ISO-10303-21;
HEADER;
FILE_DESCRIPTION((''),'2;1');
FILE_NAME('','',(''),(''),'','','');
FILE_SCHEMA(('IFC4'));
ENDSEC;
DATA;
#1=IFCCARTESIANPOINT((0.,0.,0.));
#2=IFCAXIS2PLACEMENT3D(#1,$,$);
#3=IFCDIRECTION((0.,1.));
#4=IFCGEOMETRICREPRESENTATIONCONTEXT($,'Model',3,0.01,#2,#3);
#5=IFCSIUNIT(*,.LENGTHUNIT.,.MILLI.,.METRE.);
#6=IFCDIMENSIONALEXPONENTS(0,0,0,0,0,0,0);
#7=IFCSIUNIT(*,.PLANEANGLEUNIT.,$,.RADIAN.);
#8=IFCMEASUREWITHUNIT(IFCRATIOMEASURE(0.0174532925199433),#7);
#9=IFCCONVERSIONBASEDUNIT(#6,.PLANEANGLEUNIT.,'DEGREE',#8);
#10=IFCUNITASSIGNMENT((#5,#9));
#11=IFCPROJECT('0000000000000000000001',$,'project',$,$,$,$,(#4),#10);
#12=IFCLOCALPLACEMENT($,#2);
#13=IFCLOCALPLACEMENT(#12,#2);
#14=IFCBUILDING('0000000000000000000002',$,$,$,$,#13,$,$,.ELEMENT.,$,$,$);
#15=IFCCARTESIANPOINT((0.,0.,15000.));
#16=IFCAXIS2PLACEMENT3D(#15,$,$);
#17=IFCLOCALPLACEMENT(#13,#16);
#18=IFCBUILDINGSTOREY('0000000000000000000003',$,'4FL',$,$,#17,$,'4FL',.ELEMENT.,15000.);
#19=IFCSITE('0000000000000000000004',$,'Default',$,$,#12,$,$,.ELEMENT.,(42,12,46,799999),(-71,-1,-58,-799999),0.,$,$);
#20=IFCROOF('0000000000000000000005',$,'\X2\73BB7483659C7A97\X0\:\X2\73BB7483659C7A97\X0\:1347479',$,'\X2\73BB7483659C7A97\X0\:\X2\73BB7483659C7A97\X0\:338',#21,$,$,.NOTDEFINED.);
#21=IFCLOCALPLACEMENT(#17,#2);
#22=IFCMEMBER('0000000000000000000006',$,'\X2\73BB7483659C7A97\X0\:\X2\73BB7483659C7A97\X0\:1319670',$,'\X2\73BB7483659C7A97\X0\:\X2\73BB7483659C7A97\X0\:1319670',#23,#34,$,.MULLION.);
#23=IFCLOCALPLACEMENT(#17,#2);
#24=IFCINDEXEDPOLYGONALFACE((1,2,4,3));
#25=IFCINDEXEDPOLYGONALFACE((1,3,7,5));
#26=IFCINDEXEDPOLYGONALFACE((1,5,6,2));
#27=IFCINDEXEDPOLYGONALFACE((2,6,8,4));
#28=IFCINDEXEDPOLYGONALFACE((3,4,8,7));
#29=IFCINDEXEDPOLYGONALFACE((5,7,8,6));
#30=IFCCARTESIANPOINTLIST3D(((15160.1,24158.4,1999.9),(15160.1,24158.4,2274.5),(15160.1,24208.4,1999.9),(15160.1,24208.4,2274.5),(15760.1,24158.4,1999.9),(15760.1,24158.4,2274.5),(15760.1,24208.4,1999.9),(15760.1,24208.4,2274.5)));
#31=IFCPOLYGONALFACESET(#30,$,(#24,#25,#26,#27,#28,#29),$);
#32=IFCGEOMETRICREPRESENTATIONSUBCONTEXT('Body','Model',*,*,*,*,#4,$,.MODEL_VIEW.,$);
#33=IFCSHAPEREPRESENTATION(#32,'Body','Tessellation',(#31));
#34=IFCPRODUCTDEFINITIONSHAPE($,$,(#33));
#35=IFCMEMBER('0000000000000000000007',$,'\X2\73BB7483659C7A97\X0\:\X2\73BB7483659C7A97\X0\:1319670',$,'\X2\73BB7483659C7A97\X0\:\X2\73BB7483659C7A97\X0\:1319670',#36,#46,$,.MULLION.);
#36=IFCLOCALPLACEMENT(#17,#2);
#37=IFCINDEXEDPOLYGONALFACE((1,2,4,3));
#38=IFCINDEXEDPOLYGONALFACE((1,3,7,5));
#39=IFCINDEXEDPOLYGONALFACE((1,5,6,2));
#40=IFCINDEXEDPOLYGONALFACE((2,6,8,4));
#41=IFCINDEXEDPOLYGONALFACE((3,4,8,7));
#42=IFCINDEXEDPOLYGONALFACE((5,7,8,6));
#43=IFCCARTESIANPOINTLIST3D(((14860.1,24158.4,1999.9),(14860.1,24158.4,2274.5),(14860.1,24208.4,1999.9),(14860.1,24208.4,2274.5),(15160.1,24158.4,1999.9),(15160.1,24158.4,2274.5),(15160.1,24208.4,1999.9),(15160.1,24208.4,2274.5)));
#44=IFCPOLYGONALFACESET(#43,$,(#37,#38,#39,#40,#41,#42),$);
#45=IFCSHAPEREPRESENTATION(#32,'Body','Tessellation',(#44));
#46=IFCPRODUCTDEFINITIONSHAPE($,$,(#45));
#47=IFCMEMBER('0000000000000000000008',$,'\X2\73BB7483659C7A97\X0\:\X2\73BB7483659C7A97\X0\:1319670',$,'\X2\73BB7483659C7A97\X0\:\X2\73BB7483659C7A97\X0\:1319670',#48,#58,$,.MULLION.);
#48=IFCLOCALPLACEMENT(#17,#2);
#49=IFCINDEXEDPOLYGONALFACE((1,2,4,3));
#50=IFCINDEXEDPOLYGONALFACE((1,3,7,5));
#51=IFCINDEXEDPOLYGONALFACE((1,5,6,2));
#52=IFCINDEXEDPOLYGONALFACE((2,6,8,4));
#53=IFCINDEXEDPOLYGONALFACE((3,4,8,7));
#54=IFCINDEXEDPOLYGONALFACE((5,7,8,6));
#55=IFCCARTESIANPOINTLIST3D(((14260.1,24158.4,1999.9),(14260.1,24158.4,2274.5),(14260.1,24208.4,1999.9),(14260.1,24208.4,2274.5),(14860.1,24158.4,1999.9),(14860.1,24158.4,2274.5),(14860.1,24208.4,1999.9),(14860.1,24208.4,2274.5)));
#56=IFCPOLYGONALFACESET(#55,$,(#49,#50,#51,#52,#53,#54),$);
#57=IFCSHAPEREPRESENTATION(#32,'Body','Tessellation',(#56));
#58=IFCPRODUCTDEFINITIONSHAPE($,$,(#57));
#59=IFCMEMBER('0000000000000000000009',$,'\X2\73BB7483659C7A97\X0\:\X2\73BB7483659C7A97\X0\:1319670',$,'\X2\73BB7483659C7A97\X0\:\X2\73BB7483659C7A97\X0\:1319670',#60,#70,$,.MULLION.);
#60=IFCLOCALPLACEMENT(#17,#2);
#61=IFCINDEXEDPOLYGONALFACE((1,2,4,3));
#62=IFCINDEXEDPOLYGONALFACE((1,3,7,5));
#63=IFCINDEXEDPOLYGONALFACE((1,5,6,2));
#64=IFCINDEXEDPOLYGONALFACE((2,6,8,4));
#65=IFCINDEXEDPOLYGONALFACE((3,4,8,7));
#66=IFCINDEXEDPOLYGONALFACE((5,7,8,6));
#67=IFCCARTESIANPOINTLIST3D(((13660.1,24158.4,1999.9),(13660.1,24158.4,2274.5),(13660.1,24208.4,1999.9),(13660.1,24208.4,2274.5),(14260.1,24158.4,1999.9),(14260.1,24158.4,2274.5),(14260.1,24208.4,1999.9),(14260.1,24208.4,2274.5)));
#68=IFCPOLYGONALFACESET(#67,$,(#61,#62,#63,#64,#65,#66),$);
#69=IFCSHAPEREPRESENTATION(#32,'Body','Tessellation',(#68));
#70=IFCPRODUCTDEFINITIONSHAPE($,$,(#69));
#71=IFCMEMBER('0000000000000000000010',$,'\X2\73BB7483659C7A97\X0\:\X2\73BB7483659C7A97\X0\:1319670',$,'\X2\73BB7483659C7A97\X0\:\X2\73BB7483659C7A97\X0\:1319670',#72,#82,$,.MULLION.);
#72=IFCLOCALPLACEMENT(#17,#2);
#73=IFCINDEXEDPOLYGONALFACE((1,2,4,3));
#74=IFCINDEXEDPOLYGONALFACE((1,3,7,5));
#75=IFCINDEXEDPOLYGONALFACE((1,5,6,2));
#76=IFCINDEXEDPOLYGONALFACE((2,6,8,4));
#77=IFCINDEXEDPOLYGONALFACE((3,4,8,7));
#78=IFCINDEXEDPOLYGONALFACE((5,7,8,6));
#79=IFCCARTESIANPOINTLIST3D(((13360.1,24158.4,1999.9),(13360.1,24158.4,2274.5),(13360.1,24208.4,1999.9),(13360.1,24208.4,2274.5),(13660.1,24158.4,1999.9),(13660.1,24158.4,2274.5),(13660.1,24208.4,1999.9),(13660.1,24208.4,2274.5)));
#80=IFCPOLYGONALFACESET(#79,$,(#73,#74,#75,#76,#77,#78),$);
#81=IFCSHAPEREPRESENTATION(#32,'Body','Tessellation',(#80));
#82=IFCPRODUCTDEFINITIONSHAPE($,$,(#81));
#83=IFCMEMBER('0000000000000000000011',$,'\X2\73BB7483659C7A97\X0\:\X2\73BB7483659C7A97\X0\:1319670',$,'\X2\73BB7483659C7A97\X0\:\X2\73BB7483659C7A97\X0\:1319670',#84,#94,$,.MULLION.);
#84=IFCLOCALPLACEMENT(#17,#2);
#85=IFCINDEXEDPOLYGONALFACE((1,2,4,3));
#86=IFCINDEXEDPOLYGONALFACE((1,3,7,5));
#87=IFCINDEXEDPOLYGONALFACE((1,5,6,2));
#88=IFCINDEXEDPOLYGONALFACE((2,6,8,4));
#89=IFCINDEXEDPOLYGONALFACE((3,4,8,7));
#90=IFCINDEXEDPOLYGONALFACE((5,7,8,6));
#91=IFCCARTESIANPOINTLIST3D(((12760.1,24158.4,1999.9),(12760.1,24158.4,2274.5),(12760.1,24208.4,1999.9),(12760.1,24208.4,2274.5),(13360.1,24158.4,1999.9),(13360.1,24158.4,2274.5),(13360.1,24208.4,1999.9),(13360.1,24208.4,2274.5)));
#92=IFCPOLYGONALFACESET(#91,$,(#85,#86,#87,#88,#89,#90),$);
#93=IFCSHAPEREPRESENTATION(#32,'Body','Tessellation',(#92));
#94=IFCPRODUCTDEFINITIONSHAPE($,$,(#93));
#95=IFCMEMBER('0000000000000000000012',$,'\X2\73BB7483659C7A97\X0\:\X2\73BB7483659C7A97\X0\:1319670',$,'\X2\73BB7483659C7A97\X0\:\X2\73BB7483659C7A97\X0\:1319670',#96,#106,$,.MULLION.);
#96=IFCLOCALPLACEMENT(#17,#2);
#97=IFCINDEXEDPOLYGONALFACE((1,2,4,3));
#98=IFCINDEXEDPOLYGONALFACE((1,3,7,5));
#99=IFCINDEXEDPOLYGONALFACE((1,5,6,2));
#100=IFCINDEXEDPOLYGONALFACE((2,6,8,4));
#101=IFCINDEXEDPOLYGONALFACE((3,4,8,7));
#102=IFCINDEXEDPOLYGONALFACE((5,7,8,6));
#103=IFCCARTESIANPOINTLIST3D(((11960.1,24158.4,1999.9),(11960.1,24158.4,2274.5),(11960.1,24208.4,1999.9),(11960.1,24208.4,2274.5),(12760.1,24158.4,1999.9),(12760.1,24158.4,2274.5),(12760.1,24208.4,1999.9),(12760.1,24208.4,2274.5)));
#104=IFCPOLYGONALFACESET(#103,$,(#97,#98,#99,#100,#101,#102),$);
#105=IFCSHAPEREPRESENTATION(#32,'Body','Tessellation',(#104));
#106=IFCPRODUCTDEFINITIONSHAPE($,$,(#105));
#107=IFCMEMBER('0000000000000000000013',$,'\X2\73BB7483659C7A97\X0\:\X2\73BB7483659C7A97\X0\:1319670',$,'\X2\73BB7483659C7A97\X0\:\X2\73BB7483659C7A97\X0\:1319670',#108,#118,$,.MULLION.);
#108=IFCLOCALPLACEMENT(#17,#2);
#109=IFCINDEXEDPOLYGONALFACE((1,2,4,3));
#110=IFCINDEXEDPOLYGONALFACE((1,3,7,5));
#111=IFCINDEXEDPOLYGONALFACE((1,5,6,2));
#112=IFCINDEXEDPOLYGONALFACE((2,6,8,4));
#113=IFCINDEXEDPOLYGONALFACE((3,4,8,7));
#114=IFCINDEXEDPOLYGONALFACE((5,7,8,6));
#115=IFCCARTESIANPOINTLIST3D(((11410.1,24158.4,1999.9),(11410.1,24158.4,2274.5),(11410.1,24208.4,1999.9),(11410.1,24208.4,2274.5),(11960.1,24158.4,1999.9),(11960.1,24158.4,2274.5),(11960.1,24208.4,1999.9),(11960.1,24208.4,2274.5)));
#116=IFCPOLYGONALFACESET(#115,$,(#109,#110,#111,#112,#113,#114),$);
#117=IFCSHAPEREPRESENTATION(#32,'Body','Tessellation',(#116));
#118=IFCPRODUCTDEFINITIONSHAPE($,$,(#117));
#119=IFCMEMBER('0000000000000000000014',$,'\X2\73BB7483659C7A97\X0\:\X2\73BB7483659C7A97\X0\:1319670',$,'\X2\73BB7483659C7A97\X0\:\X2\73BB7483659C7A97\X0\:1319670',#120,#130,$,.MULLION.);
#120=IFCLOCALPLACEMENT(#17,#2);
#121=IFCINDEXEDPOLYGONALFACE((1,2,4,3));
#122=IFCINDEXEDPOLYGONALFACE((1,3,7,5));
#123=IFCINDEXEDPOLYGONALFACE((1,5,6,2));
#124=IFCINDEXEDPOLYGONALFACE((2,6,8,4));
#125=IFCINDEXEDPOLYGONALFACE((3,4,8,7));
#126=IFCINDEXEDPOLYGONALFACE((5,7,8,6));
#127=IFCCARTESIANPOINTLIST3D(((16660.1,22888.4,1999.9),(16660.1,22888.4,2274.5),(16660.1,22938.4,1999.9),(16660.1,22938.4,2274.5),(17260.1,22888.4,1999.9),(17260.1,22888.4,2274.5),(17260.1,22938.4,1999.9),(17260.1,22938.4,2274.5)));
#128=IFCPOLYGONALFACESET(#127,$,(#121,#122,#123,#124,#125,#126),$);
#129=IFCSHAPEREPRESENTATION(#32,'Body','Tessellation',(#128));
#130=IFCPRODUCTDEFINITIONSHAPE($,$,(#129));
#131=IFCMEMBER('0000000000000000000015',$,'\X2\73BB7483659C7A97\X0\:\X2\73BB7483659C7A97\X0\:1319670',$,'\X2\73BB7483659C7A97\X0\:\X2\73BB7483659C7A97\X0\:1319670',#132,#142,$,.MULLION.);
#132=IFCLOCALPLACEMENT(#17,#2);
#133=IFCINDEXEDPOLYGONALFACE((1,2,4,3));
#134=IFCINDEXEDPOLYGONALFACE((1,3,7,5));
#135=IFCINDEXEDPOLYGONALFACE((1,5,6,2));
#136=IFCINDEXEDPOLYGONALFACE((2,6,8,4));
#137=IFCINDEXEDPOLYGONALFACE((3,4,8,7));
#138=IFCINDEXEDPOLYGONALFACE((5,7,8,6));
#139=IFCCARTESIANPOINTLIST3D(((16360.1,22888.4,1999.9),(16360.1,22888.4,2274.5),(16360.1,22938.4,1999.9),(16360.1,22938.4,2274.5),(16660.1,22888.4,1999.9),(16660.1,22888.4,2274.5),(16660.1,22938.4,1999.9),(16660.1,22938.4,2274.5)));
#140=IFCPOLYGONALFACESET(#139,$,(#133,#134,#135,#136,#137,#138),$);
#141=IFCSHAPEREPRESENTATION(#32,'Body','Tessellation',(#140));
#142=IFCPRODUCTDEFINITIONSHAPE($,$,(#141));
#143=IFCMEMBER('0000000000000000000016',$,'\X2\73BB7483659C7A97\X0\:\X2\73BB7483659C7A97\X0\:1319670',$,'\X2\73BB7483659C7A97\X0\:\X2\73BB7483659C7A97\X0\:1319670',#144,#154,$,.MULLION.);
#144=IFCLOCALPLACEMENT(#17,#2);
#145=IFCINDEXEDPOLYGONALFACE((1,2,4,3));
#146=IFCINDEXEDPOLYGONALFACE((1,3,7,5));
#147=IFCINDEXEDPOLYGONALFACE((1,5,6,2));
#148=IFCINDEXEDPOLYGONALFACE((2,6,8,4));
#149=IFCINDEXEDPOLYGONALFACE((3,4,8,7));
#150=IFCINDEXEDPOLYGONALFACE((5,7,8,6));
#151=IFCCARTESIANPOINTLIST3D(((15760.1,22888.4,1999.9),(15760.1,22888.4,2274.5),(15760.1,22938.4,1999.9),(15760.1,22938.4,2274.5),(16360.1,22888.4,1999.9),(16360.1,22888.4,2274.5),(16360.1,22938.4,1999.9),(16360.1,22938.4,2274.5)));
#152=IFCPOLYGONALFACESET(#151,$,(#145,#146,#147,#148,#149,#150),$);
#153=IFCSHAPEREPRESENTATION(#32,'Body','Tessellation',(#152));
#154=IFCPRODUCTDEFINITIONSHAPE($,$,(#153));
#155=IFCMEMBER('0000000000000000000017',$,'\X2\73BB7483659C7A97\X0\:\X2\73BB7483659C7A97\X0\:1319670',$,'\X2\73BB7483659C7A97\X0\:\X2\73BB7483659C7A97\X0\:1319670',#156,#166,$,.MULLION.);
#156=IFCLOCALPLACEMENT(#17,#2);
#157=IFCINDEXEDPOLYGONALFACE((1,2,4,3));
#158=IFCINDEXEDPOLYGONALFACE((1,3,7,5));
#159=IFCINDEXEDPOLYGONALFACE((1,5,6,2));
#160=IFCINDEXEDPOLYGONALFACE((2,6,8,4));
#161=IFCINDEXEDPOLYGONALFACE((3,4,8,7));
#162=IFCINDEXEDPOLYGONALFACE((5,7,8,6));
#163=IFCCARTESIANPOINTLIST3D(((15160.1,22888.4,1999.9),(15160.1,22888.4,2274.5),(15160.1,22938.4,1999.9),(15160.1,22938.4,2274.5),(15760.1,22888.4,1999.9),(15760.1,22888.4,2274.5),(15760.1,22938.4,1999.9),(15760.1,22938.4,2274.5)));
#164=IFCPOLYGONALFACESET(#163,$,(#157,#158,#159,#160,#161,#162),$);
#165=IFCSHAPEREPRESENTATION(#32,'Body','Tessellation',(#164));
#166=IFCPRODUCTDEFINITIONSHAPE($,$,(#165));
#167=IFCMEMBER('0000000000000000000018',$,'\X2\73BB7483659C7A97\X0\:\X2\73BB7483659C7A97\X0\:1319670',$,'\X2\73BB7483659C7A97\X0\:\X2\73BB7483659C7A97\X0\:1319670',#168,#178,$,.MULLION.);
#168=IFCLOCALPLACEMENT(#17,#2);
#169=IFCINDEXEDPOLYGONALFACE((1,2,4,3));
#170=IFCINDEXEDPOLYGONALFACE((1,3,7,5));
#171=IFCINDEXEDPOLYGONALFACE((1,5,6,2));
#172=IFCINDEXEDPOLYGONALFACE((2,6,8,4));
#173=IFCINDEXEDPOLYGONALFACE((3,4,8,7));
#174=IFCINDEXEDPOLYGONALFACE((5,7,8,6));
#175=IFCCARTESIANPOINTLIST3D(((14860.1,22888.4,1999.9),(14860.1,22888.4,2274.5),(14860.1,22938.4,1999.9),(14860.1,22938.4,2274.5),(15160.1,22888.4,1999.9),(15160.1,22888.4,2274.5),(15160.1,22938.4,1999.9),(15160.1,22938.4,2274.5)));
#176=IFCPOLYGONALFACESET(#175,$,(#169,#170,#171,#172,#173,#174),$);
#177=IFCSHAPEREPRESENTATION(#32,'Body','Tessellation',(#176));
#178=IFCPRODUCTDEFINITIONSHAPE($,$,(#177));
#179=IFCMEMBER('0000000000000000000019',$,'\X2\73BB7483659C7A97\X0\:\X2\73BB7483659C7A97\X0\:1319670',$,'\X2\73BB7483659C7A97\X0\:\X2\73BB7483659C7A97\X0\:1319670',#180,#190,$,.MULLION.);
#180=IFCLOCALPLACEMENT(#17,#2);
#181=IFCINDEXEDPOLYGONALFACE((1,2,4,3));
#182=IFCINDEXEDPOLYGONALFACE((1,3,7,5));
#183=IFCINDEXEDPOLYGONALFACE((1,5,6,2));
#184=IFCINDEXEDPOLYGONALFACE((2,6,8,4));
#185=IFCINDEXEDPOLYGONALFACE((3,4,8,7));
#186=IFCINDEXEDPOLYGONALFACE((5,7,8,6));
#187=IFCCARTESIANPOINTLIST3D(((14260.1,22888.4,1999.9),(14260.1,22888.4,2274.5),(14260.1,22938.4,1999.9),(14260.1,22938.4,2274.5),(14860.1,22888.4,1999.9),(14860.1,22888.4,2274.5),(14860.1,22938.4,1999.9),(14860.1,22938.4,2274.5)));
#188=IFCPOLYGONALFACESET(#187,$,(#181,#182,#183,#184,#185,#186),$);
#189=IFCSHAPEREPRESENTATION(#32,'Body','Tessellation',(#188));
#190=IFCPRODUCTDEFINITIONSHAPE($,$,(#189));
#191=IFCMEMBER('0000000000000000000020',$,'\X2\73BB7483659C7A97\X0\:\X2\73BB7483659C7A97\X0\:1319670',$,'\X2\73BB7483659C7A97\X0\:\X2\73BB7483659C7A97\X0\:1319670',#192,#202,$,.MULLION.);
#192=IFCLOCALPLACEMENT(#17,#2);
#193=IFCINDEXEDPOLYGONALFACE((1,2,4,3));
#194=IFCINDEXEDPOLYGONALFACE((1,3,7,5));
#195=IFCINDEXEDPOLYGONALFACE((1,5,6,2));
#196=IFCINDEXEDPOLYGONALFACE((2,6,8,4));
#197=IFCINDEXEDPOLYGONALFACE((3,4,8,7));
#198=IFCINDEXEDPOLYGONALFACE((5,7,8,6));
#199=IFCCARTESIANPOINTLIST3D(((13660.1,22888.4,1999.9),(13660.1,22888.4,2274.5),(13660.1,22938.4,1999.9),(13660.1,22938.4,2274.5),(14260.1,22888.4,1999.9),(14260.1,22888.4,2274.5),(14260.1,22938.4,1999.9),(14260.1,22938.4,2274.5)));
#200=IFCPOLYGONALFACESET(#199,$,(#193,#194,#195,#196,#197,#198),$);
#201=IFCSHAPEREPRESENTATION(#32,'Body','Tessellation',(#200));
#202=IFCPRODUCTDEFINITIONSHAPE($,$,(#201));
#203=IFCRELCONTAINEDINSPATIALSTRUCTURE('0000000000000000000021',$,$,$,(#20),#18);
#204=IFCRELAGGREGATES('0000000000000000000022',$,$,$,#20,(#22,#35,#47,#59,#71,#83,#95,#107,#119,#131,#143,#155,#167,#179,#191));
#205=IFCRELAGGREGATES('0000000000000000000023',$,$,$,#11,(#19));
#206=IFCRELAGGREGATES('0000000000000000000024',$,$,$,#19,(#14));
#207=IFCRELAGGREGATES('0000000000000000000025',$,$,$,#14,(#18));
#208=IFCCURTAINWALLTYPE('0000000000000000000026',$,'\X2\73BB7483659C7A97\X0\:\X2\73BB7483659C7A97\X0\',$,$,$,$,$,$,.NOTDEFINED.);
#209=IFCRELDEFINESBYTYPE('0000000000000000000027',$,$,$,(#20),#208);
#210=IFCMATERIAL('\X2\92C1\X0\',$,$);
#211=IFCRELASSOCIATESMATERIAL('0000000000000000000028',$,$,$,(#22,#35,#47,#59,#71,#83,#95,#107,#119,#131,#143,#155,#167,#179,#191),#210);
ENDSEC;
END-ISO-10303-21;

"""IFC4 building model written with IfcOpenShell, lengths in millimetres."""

from ifc_helpers import new_model, entity, si_unit, converted_unit, direction, frame, frame_2d, origin, place, context, subcontext, project, spatial, rectangle, extrude, material, type_object, element, aggregate, save


model = new_model("IFC4")

# Units and contexts
model_context = context("Model", 3, precision=0.01, world=origin(), true_north=direction((0.0, 1.0)))
body_context = subcontext(model_context, "Body", "Model", "MODEL_VIEW")
ifc_project = project(units=[si_unit("LENGTHUNIT", "METRE", prefix="MILLI"), converted_unit("PLANEANGLEUNIT", "DEGREE", entity("IfcRatioMeasure", 0.0174532925199433), si_unit("PLANEANGLEUNIT", "RADIAN"), dimensions=[0, 0, 0, 0, 0, 0, 0])], contexts=[model_context])

# Site, building, storey
site_placement = place(None, origin())
site = spatial("IfcSite", under=ifc_project, at=site_placement, Name="Default", CompositionType="ELEMENT", RefLatitude=(42, 12, 46, 799999), RefLongitude=(-71, -1, -58, -799999), RefElevation=0.0)
building_placement = place(site_placement, origin())
building = spatial("IfcBuilding", under=site, at=building_placement, CompositionType="ELEMENT")
storey_placement = place(building_placement, frame((0.0, 0.0, 15000.0)))
storey = spatial("IfcBuildingStorey", under=building, at=storey_placement, Name="4FL", LongName="4FL", CompositionType="ELEMENT", Elevation=15000.0)

# Roof, members
curtain_wall_type = type_object("IfcCurtainWallType", Name="玻璃斜窗:玻璃斜窗", PredefinedType="NOTDEFINED")
roof_1_placement = place(storey_placement, frame((0.0, 0.0, -15000.0)))
roof_1 = element("IfcRoof", 1, at=roof_1_placement, inside=storey, type_object=curtain_wall_type, Name="玻璃斜窗:玻璃斜窗:1347479", ObjectType="玻璃斜窗:玻璃斜窗:338", PredefinedType="NOTDEFINED")
ifc_material = material(Name="鋁")
member_1_placement = place(roof_1_placement, frame((0.0, 0.0, 15000.0)))
member_1 = element("IfcMember", 2, at=member_1_placement, material=ifc_material, Name="玻璃斜窗:玻璃斜窗:1319670", ObjectType="玻璃斜窗:玻璃斜窗:1319670", PredefinedType="MULLION", context=body_context, shape_type="SweptSolid", body=[
    extrude(rectangle(XDim=274.5, YDim=50.0, at=frame_2d((0.0, 0.0), x_axis=(1.0, 0.0))), frame((15160.1, 24183.4, 2137.2), z_axis=(1.0, 0.0, 0.0), x_axis=(0.0, 0.0, -1.0)), (0.0, 0.0, 1.0), 600.0),
])
member_2_placement = place(roof_1_placement, frame((0.0, 0.0, 15000.0)))
member_2 = element("IfcMember", 3, at=member_2_placement, material=ifc_material, Name="玻璃斜窗:玻璃斜窗:1319670", ObjectType="玻璃斜窗:玻璃斜窗:1319670", PredefinedType="MULLION", context=body_context, shape_type="SweptSolid", body=[
    extrude(rectangle(XDim=274.5, YDim=50.0, at=frame_2d((0.0, 0.0), x_axis=(1.0, 0.0))), frame((14860.1, 24183.4, 2137.2), z_axis=(1.0, 0.0, 0.0), x_axis=(0.0, 0.0, -1.0)), (0.0, 0.0, 1.0), 300.0),
])
member_3_placement = place(roof_1_placement, frame((0.0, 0.0, 15000.0)))
member_3 = element("IfcMember", 4, at=member_3_placement, material=ifc_material, Name="玻璃斜窗:玻璃斜窗:1319670", ObjectType="玻璃斜窗:玻璃斜窗:1319670", PredefinedType="MULLION", context=body_context, shape_type="SweptSolid", body=[
    extrude(rectangle(XDim=274.5, YDim=50.0, at=frame_2d((0.0, 0.0), x_axis=(1.0, 0.0))), frame((14260.1, 24183.4, 2137.2), z_axis=(1.0, 0.0, 0.0), x_axis=(0.0, 0.0, -1.0)), (0.0, 0.0, 1.0), 600.0),
])
member_4_placement = place(roof_1_placement, frame((0.0, 0.0, 15000.0)))
member_4 = element("IfcMember", 5, at=member_4_placement, material=ifc_material, Name="玻璃斜窗:玻璃斜窗:1319670", ObjectType="玻璃斜窗:玻璃斜窗:1319670", PredefinedType="MULLION", context=body_context, shape_type="SweptSolid", body=[
    extrude(rectangle(XDim=274.5, YDim=50.0, at=frame_2d((0.0, 0.0), x_axis=(1.0, 0.0))), frame((13660.1, 24183.4, 2137.2), z_axis=(1.0, 0.0, 0.0), x_axis=(0.0, 0.0, -1.0)), (0.0, 0.0, 1.0), 600.0),
])
member_5_placement = place(roof_1_placement, frame((0.0, 0.0, 15000.0)))
member_5 = element("IfcMember", 6, at=member_5_placement, material=ifc_material, Name="玻璃斜窗:玻璃斜窗:1319670", ObjectType="玻璃斜窗:玻璃斜窗:1319670", PredefinedType="MULLION", context=body_context, shape_type="SweptSolid", body=[
    extrude(rectangle(XDim=274.5, YDim=50.0, at=frame_2d((0.0, 0.0), x_axis=(1.0, 0.0))), frame((13360.1, 24183.4, 2137.2), z_axis=(1.0, 0.0, 0.0), x_axis=(0.0, 0.0, -1.0)), (0.0, 0.0, 1.0), 300.0),
])
member_6_placement = place(roof_1_placement, frame((0.0, 0.0, 15000.0)))
member_6 = element("IfcMember", 7, at=member_6_placement, material=ifc_material, Name="玻璃斜窗:玻璃斜窗:1319670", ObjectType="玻璃斜窗:玻璃斜窗:1319670", PredefinedType="MULLION", context=body_context, shape_type="SweptSolid", body=[
    extrude(rectangle(XDim=274.5, YDim=50.0, at=frame_2d((0.0, 0.0), x_axis=(1.0, 0.0))), frame((12760.1, 24183.4, 2137.2), z_axis=(1.0, 0.0, 0.0), x_axis=(0.0, 0.0, -1.0)), (0.0, 0.0, 1.0), 600.0),
])
member_7_placement = place(roof_1_placement, frame((0.0, 0.0, 15000.0)))
member_7 = element("IfcMember", 8, at=member_7_placement, material=ifc_material, Name="玻璃斜窗:玻璃斜窗:1319670", ObjectType="玻璃斜窗:玻璃斜窗:1319670", PredefinedType="MULLION", context=body_context, shape_type="SweptSolid", body=[
    extrude(rectangle(XDim=274.5, YDim=50.0, at=frame_2d((0.0, 0.0), x_axis=(1.0, 0.0))), frame((11960.1, 24183.4, 2137.2), z_axis=(1.0, 0.0, 0.0), x_axis=(0.0, 0.0, -1.0)), (0.0, 0.0, 1.0), 800.0),
])
member_8_placement = place(roof_1_placement, frame((0.0, 0.0, 15000.0)))
member_8 = element("IfcMember", 9, at=member_8_placement, material=ifc_material, Name="玻璃斜窗:玻璃斜窗:1319670", ObjectType="玻璃斜窗:玻璃斜窗:1319670", PredefinedType="MULLION", context=body_context, shape_type="SweptSolid", body=[
    extrude(rectangle(XDim=274.5, YDim=50.0, at=frame_2d((0.0, 0.0), x_axis=(1.0, 0.0))), frame((11410.1, 24183.4, 2137.2), z_axis=(1.0, 0.0, 0.0), x_axis=(0.0, 0.0, -1.0)), (0.0, 0.0, 1.0), 550.0),
])
member_9_placement = place(roof_1_placement, frame((0.0, 0.0, 15000.0)))
member_9 = element("IfcMember", 10, at=member_9_placement, material=ifc_material, Name="玻璃斜窗:玻璃斜窗:1319670", ObjectType="玻璃斜窗:玻璃斜窗:1319670", PredefinedType="MULLION", context=body_context, shape_type="SweptSolid", body=[
    extrude(rectangle(XDim=274.5, YDim=50.0, at=frame_2d((0.0, 0.0), x_axis=(1.0, 0.0))), frame((17260.1, 22913.4, 2137.2), z_axis=(-1.0, 0.0, 0.0), x_axis=(0.0, 0.0, -1.0)), (0.0, 0.0, 1.0), 600.0),
])
member_10_placement = place(roof_1_placement, frame((0.0, 0.0, 15000.0)))
member_10 = element("IfcMember", 11, at=member_10_placement, material=ifc_material, Name="玻璃斜窗:玻璃斜窗:1319670", ObjectType="玻璃斜窗:玻璃斜窗:1319670", PredefinedType="MULLION", context=body_context, shape_type="SweptSolid", body=[
    extrude(rectangle(XDim=274.5, YDim=50.0, at=frame_2d((0.0, 0.0), x_axis=(1.0, 0.0))), frame((16660.1, 22913.4, 2137.2), z_axis=(-1.0, 0.0, 0.0), x_axis=(0.0, 0.0, -1.0)), (0.0, 0.0, 1.0), 300.0),
])
member_11_placement = place(roof_1_placement, frame((0.0, 0.0, 15000.0)))
member_11 = element("IfcMember", 12, at=member_11_placement, material=ifc_material, Name="玻璃斜窗:玻璃斜窗:1319670", ObjectType="玻璃斜窗:玻璃斜窗:1319670", PredefinedType="MULLION", context=body_context, shape_type="SweptSolid", body=[
    extrude(rectangle(XDim=274.5, YDim=50.0, at=frame_2d((0.0, 0.0), x_axis=(1.0, 0.0))), frame((16360.1, 22913.4, 2137.2), z_axis=(-1.0, 0.0, 0.0), x_axis=(0.0, 0.0, -1.0)), (0.0, 0.0, 1.0), 600.0),
])
member_12_placement = place(roof_1_placement, frame((0.0, 0.0, 15000.0)))
member_12 = element("IfcMember", 13, at=member_12_placement, material=ifc_material, Name="玻璃斜窗:玻璃斜窗:1319670", ObjectType="玻璃斜窗:玻璃斜窗:1319670", PredefinedType="MULLION", context=body_context, shape_type="SweptSolid", body=[
    extrude(rectangle(XDim=274.5, YDim=50.0, at=frame_2d((0.0, 0.0), x_axis=(1.0, 0.0))), frame((15760.1, 22913.4, 2137.2), z_axis=(-1.0, 0.0, 0.0), x_axis=(0.0, 0.0, -1.0)), (0.0, 0.0, 1.0), 600.0),
])
member_13_placement = place(roof_1_placement, frame((0.0, 0.0, 15000.0)))
member_13 = element("IfcMember", 14, at=member_13_placement, material=ifc_material, Name="玻璃斜窗:玻璃斜窗:1319670", ObjectType="玻璃斜窗:玻璃斜窗:1319670", PredefinedType="MULLION", context=body_context, shape_type="SweptSolid", body=[
    extrude(rectangle(XDim=274.5, YDim=50.0, at=frame_2d((0.0, 0.0), x_axis=(1.0, 0.0))), frame((15160.1, 22913.4, 2137.2), z_axis=(-1.0, 0.0, 0.0), x_axis=(0.0, 0.0, -1.0)), (0.0, 0.0, 1.0), 300.0),
])
member_14_placement = place(roof_1_placement, frame((0.0, 0.0, 15000.0)))
member_14 = element("IfcMember", 15, at=member_14_placement, material=ifc_material, Name="玻璃斜窗:玻璃斜窗:1319670", ObjectType="玻璃斜窗:玻璃斜窗:1319670", PredefinedType="MULLION", context=body_context, shape_type="SweptSolid", body=[
    extrude(rectangle(XDim=274.5, YDim=50.0, at=frame_2d((0.0, 0.0), x_axis=(1.0, 0.0))), frame((14860.1, 22913.4, 2137.2), z_axis=(-1.0, 0.0, 0.0), x_axis=(0.0, 0.0, -1.0)), (0.0, 0.0, 1.0), 600.0),
])
member_15_placement = place(roof_1_placement, frame((0.0, 0.0, 15000.0)))
member_15 = element("IfcMember", 16, at=member_15_placement, material=ifc_material, Name="玻璃斜窗:玻璃斜窗:1319670", ObjectType="玻璃斜窗:玻璃斜窗:1319670", PredefinedType="MULLION", context=body_context, shape_type="SweptSolid", body=[
    extrude(rectangle(XDim=274.5, YDim=50.0, at=frame_2d((0.0, 0.0), x_axis=(1.0, 0.0))), frame((14260.1, 22913.4, 2137.2), z_axis=(-1.0, 0.0, 0.0), x_axis=(0.0, 0.0, -1.0)), (0.0, 0.0, 1.0), 600.0),
])
aggregate(roof_1, [member_1, member_2, member_3, member_4, member_5, member_6, member_7, member_8, member_9, member_10, member_11, member_12, member_13, member_14, member_15])

save(model, "model.ifc")
